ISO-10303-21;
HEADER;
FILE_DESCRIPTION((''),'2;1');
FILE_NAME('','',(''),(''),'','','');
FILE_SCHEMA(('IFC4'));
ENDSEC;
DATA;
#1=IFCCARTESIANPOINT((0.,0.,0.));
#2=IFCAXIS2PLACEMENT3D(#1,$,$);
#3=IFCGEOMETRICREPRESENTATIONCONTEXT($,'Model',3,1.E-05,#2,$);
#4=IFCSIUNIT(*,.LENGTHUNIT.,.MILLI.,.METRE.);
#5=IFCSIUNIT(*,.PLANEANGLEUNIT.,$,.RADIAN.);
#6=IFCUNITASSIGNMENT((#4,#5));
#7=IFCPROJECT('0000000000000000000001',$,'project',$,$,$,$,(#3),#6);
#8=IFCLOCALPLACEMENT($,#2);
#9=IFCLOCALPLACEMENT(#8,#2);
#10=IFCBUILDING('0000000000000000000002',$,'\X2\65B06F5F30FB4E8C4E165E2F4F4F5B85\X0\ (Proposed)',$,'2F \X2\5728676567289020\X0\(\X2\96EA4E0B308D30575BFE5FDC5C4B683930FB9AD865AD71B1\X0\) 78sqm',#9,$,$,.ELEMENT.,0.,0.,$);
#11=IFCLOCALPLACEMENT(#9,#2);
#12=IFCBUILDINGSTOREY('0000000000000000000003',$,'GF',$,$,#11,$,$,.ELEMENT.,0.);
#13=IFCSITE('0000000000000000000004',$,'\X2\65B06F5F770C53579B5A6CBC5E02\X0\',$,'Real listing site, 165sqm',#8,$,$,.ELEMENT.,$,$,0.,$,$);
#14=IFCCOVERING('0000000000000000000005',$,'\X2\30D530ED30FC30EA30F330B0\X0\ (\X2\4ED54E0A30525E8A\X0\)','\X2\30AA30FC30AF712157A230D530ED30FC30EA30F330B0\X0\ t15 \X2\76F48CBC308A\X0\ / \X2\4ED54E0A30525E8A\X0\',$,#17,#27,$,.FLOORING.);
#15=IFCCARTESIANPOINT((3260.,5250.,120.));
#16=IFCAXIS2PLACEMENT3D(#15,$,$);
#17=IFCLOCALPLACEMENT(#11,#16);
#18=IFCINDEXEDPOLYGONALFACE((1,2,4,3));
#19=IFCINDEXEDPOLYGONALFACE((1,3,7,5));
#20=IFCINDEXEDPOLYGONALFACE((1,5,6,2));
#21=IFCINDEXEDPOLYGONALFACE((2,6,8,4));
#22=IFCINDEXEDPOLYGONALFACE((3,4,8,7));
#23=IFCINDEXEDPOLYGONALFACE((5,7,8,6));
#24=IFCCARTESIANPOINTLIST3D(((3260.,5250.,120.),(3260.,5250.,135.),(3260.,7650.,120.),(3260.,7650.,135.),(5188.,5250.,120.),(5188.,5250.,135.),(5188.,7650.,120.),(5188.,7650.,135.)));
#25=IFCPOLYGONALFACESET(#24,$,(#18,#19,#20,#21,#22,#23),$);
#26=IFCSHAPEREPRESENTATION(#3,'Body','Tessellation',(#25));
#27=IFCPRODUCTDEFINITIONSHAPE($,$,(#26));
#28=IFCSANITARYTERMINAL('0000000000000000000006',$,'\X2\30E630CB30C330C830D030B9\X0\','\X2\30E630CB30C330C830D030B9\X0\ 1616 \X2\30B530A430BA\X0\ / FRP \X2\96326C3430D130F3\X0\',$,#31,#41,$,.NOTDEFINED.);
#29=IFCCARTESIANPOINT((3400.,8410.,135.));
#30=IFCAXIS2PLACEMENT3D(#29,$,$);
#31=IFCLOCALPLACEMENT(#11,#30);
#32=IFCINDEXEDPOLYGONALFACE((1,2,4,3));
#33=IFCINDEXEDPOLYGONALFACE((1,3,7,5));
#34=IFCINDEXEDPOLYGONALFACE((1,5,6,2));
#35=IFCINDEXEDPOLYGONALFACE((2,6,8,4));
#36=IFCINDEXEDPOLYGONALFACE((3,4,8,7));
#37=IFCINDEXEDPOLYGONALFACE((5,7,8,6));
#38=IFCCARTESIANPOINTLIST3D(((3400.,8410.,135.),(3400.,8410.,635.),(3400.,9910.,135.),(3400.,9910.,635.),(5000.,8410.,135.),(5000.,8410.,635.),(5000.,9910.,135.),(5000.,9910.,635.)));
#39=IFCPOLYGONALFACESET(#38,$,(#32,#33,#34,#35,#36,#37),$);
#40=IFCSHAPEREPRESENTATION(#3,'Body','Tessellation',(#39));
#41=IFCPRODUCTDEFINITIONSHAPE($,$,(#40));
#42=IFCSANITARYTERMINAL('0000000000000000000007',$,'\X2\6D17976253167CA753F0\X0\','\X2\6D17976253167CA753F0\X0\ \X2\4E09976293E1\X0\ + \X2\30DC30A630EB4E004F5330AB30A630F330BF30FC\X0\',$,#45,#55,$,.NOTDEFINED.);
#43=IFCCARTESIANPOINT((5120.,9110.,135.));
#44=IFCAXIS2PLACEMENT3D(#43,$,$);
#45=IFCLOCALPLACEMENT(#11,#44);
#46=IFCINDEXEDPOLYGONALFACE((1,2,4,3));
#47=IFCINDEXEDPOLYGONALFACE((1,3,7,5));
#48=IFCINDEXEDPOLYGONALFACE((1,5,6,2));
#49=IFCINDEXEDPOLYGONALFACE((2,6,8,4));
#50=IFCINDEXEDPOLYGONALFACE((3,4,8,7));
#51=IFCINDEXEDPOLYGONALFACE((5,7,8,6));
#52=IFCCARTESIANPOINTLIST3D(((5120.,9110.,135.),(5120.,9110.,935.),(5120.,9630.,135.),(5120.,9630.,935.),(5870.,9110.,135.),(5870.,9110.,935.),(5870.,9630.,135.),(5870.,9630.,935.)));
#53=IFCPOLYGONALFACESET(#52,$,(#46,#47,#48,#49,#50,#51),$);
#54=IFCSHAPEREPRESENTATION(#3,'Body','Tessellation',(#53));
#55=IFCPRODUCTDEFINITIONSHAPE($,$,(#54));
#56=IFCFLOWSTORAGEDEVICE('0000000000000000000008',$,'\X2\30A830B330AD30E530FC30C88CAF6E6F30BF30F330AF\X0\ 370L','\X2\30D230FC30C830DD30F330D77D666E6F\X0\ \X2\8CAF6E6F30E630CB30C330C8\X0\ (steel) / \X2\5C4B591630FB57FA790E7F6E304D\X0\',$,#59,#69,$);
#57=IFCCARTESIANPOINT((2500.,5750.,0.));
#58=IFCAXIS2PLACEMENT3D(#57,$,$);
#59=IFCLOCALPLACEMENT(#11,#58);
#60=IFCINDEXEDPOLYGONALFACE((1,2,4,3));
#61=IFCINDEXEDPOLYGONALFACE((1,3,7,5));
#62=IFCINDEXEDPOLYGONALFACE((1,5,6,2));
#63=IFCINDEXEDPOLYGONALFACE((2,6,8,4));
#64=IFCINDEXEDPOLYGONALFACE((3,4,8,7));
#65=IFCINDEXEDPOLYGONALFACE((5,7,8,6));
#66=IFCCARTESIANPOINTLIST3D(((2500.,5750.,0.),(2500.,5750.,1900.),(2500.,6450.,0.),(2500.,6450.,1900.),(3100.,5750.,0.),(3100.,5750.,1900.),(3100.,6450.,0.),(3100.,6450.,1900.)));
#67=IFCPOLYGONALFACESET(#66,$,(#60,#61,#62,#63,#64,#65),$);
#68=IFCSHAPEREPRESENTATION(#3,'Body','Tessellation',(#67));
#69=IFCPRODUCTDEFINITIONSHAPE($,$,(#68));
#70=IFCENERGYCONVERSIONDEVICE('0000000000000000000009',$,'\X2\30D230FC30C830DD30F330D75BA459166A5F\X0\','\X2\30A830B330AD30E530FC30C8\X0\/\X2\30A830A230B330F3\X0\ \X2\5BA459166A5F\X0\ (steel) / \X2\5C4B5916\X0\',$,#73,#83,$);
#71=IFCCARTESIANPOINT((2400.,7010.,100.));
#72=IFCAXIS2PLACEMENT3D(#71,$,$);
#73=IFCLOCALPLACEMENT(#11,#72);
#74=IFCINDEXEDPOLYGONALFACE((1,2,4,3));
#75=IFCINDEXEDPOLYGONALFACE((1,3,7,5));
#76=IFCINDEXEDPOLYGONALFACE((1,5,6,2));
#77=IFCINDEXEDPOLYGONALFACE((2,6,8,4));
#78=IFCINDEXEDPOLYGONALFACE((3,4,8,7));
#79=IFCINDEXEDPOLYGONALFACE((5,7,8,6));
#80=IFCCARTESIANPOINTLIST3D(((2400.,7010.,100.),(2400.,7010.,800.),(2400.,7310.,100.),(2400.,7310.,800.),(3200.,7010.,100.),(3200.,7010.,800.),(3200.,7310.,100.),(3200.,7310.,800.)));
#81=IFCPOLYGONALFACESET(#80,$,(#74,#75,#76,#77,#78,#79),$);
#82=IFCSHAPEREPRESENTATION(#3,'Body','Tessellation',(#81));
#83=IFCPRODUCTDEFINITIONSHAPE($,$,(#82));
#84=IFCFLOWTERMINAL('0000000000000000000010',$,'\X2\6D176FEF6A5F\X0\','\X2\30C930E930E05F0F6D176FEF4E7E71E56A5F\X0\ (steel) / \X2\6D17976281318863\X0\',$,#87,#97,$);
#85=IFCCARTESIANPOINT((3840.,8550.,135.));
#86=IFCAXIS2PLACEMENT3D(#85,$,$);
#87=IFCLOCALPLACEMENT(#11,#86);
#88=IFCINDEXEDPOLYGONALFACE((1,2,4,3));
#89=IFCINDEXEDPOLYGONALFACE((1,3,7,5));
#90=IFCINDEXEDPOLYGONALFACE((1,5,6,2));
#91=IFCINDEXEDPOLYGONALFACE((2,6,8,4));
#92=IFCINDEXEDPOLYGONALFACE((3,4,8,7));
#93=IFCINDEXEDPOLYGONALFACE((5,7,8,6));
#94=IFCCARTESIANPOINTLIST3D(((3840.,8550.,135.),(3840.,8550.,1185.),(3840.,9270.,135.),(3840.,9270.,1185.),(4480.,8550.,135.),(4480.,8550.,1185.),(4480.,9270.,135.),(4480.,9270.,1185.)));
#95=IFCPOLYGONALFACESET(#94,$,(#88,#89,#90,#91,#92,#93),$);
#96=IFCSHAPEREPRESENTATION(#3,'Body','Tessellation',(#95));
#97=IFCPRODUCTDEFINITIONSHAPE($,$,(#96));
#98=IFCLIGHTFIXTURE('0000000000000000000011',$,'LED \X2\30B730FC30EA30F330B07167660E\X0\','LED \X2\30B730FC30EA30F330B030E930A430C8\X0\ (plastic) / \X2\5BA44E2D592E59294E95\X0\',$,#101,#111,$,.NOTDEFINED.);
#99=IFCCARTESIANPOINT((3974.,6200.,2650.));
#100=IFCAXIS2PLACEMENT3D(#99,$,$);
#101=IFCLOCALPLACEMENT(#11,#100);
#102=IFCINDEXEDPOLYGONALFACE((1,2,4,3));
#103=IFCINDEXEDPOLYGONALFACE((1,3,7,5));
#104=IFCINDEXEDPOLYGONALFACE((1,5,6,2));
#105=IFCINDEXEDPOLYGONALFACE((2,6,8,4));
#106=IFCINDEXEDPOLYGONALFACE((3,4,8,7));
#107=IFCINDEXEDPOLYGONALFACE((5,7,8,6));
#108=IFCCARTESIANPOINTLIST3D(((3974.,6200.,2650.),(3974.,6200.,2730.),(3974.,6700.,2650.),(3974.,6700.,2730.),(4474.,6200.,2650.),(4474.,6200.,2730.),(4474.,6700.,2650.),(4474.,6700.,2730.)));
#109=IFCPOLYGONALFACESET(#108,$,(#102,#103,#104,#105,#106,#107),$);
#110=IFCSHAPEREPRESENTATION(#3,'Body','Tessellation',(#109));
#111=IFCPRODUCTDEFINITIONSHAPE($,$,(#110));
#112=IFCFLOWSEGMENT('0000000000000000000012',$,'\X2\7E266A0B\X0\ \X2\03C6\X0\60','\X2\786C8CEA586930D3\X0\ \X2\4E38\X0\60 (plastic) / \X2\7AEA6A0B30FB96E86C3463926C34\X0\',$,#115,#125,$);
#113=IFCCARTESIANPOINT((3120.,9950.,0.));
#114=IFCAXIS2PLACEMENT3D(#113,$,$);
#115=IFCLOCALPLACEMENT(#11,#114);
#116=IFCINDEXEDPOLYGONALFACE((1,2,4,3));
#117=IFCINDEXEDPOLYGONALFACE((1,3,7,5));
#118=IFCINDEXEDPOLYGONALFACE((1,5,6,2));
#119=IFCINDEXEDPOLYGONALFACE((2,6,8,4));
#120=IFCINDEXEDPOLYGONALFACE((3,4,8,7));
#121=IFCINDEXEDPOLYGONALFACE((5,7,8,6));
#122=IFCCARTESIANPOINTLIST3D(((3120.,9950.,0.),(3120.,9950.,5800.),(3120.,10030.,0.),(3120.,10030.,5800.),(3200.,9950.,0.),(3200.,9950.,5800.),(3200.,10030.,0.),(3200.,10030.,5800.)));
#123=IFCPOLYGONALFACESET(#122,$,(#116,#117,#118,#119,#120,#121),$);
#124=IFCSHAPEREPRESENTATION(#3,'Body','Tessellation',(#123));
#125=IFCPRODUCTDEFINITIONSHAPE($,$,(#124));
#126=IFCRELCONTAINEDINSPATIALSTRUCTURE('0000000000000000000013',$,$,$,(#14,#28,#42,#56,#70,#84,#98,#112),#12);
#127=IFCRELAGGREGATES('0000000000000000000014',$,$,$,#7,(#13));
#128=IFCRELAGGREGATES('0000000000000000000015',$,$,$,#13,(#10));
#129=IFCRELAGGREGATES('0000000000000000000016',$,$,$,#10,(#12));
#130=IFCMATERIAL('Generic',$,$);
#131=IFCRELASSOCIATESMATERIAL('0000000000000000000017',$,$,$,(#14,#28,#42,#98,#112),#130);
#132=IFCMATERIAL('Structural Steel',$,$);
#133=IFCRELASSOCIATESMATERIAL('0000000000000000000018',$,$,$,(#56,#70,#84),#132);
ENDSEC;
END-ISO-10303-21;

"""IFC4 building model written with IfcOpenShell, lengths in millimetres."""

from ifc_helpers import new_model, si_unit, frame, frame_2d, origin, place, context, project, spatial, rectangle, extrude, material, element, save


model = new_model("IFC4")

# Units and contexts
model_context = context("Model", 3, precision=1e-05, world=origin())
ifc_project = project(units=[si_unit("LENGTHUNIT", "METRE", prefix="MILLI"), si_unit("PLANEANGLEUNIT", "RADIAN")], contexts=[model_context])

# Site, building, storey
site_placement = place(None, origin())
site = spatial("IfcSite", under=ifc_project, at=site_placement, Name="新潟県南魚沼市", ObjectType="Real listing site, 165sqm", CompositionType="ELEMENT", RefElevation=0.0)
building_placement = place(site_placement, origin())
building = spatial("IfcBuilding", under=site, at=building_placement, Name="新潟・二世帯住宅 (Proposed)", ObjectType="2F 在来木造(雪下ろし対応屋根・高断熱) 78sqm", CompositionType="ELEMENT", ElevationOfRefHeight=0.0, ElevationOfTerrain=0.0)
storey_placement = place(building_placement, origin())
storey = spatial("IfcBuildingStorey", under=building, at=storey_placement, Name="GF", CompositionType="ELEMENT", Elevation=0.0)

# Covering
ifc_material_1 = material(Name="Generic")
covering_1_placement = place(storey_placement, frame((3260.0, 5250.0, 120.0)))
element("IfcCovering", 1, at=covering_1_placement, inside=storey, material=ifc_material_1, Name="フローリング (仕上げ床)", Description="オーク無垢フローリング t15 直貼り / 仕上げ床", PredefinedType="FLOORING", context=model_context, shape_type="SweptSolid", body=[
    extrude(rectangle(XDim=1928.0, YDim=2400.0, at=frame_2d((964.0, 1200.0))), frame((3260.0, 5250.0, 120.0)), (0.0, 0.0, 1.0), 15.0),
])

# Sanitary terminals
sanitary_terminal_1_placement = place(storey_placement, frame((3400.0, 8410.0, 135.0)))
element("IfcSanitaryTerminal", 2, at=sanitary_terminal_1_placement, inside=storey, material=ifc_material_1, Name="ユニットバス", Description="ユニットバス 1616 サイズ / FRP 防水パン", PredefinedType="NOTDEFINED", context=model_context, shape_type="SweptSolid", body=[
    extrude(rectangle(XDim=1600.0, YDim=1500.0, at=frame_2d((800.0, 750.0))), frame((3400.0, 8410.0, 135.0)), (0.0, 0.0, 1.0), 500.0),
])
sanitary_terminal_2_placement = place(storey_placement, frame((5120.0, 9110.0, 135.0)))
element("IfcSanitaryTerminal", 3, at=sanitary_terminal_2_placement, inside=storey, material=ifc_material_1, Name="洗面化粧台", Description="洗面化粧台 三面鏡 + ボウル一体カウンター", PredefinedType="NOTDEFINED", context=model_context, shape_type="SweptSolid", body=[
    extrude(rectangle(XDim=750.0, YDim=520.0, at=frame_2d((375.0, 260.0))), frame((5120.0, 9110.0, 135.0)), (0.0, 0.0, 1.0), 800.0),
])

# Flow storage device
ifc_material_2 = material(Name="Structural Steel")
flow_storage_device_placement = place(storey_placement, frame((2500.0, 5750.0, 0.0)))
element("IfcFlowStorageDevice", 4, at=flow_storage_device_placement, inside=storey, material=ifc_material_2, Name="エコキュート貯湯タンク 370L", Description="ヒートポンプ給湯 貯湯ユニット (steel) / 屋外・基礎置き", context=model_context, shape_type="SweptSolid", body=[
    extrude(rectangle(XDim=600.0, YDim=700.0, at=frame_2d((300.0, 350.0))), frame((2500.0, 5750.0, 0.0)), (0.0, 0.0, 1.0), 1900.0),
])

# Energy conversion device
energy_conversion_device_placement = place(storey_placement, frame((2400.0, 7010.0, 100.0)))
element("IfcEnergyConversionDevice", 5, at=energy_conversion_device_placement, inside=storey, material=ifc_material_2, Name="ヒートポンプ室外機", Description="エコキュート/エアコン 室外機 (steel) / 屋外", context=model_context, shape_type="SweptSolid", body=[
    extrude(rectangle(XDim=800.0, YDim=300.0, at=frame_2d((400.0, 150.0))), frame((2400.0, 7010.0, 100.0)), (0.0, 0.0, 1.0), 700.0),
])

# Flow terminal
flow_terminal_placement = place(storey_placement, frame((3840.0, 8550.0, 135.0)))
element("IfcFlowTerminal", 6, at=flow_terminal_placement, inside=storey, material=ifc_material_2, Name="洗濯機", Description="ドラム式洗濯乾燥機 (steel) / 洗面脱衣", context=model_context, shape_type="SweptSolid", body=[
    extrude(rectangle(XDim=640.0, YDim=720.0, at=frame_2d((320.0, 360.0))), frame((3840.0, 8550.0, 135.0)), (0.0, 0.0, 1.0), 1050.0),
])

# Light fixture
light_fixture_placement = place(storey_placement, frame((3974.0, 6200.0, 2650.0)))
element("IfcLightFixture", 7, at=light_fixture_placement, inside=storey, material=ifc_material_1, Name="LED シーリング照明", Description="LED シーリングライト (plastic) / 室中央天井", PredefinedType="NOTDEFINED", context=model_context, shape_type="SweptSolid", body=[
    extrude(rectangle(XDim=500.0, YDim=500.0, at=frame_2d((250.0, 250.0))), frame((3974.0, 6200.0, 2650.0)), (0.0, 0.0, 1.0), 80.0),
])

# Flow segment
flow_segment_placement = place(storey_placement, frame((3120.0, 9950.0, 0.0)))
element("IfcFlowSegment", 8, at=flow_segment_placement, inside=storey, material=ifc_material_1, Name="縦樋 φ60", Description="硬質塩ビ 丸60 (plastic) / 竪樋・雨水排水", context=model_context, shape_type="SweptSolid", body=[
    extrude(rectangle(XDim=80.0, YDim=80.0, at=frame_2d((40.0, 40.0))), frame((3120.0, 9950.0, 0.0)), (0.0, 0.0, 1.0), 5800.0),
])

save(model, "model.ifc")
